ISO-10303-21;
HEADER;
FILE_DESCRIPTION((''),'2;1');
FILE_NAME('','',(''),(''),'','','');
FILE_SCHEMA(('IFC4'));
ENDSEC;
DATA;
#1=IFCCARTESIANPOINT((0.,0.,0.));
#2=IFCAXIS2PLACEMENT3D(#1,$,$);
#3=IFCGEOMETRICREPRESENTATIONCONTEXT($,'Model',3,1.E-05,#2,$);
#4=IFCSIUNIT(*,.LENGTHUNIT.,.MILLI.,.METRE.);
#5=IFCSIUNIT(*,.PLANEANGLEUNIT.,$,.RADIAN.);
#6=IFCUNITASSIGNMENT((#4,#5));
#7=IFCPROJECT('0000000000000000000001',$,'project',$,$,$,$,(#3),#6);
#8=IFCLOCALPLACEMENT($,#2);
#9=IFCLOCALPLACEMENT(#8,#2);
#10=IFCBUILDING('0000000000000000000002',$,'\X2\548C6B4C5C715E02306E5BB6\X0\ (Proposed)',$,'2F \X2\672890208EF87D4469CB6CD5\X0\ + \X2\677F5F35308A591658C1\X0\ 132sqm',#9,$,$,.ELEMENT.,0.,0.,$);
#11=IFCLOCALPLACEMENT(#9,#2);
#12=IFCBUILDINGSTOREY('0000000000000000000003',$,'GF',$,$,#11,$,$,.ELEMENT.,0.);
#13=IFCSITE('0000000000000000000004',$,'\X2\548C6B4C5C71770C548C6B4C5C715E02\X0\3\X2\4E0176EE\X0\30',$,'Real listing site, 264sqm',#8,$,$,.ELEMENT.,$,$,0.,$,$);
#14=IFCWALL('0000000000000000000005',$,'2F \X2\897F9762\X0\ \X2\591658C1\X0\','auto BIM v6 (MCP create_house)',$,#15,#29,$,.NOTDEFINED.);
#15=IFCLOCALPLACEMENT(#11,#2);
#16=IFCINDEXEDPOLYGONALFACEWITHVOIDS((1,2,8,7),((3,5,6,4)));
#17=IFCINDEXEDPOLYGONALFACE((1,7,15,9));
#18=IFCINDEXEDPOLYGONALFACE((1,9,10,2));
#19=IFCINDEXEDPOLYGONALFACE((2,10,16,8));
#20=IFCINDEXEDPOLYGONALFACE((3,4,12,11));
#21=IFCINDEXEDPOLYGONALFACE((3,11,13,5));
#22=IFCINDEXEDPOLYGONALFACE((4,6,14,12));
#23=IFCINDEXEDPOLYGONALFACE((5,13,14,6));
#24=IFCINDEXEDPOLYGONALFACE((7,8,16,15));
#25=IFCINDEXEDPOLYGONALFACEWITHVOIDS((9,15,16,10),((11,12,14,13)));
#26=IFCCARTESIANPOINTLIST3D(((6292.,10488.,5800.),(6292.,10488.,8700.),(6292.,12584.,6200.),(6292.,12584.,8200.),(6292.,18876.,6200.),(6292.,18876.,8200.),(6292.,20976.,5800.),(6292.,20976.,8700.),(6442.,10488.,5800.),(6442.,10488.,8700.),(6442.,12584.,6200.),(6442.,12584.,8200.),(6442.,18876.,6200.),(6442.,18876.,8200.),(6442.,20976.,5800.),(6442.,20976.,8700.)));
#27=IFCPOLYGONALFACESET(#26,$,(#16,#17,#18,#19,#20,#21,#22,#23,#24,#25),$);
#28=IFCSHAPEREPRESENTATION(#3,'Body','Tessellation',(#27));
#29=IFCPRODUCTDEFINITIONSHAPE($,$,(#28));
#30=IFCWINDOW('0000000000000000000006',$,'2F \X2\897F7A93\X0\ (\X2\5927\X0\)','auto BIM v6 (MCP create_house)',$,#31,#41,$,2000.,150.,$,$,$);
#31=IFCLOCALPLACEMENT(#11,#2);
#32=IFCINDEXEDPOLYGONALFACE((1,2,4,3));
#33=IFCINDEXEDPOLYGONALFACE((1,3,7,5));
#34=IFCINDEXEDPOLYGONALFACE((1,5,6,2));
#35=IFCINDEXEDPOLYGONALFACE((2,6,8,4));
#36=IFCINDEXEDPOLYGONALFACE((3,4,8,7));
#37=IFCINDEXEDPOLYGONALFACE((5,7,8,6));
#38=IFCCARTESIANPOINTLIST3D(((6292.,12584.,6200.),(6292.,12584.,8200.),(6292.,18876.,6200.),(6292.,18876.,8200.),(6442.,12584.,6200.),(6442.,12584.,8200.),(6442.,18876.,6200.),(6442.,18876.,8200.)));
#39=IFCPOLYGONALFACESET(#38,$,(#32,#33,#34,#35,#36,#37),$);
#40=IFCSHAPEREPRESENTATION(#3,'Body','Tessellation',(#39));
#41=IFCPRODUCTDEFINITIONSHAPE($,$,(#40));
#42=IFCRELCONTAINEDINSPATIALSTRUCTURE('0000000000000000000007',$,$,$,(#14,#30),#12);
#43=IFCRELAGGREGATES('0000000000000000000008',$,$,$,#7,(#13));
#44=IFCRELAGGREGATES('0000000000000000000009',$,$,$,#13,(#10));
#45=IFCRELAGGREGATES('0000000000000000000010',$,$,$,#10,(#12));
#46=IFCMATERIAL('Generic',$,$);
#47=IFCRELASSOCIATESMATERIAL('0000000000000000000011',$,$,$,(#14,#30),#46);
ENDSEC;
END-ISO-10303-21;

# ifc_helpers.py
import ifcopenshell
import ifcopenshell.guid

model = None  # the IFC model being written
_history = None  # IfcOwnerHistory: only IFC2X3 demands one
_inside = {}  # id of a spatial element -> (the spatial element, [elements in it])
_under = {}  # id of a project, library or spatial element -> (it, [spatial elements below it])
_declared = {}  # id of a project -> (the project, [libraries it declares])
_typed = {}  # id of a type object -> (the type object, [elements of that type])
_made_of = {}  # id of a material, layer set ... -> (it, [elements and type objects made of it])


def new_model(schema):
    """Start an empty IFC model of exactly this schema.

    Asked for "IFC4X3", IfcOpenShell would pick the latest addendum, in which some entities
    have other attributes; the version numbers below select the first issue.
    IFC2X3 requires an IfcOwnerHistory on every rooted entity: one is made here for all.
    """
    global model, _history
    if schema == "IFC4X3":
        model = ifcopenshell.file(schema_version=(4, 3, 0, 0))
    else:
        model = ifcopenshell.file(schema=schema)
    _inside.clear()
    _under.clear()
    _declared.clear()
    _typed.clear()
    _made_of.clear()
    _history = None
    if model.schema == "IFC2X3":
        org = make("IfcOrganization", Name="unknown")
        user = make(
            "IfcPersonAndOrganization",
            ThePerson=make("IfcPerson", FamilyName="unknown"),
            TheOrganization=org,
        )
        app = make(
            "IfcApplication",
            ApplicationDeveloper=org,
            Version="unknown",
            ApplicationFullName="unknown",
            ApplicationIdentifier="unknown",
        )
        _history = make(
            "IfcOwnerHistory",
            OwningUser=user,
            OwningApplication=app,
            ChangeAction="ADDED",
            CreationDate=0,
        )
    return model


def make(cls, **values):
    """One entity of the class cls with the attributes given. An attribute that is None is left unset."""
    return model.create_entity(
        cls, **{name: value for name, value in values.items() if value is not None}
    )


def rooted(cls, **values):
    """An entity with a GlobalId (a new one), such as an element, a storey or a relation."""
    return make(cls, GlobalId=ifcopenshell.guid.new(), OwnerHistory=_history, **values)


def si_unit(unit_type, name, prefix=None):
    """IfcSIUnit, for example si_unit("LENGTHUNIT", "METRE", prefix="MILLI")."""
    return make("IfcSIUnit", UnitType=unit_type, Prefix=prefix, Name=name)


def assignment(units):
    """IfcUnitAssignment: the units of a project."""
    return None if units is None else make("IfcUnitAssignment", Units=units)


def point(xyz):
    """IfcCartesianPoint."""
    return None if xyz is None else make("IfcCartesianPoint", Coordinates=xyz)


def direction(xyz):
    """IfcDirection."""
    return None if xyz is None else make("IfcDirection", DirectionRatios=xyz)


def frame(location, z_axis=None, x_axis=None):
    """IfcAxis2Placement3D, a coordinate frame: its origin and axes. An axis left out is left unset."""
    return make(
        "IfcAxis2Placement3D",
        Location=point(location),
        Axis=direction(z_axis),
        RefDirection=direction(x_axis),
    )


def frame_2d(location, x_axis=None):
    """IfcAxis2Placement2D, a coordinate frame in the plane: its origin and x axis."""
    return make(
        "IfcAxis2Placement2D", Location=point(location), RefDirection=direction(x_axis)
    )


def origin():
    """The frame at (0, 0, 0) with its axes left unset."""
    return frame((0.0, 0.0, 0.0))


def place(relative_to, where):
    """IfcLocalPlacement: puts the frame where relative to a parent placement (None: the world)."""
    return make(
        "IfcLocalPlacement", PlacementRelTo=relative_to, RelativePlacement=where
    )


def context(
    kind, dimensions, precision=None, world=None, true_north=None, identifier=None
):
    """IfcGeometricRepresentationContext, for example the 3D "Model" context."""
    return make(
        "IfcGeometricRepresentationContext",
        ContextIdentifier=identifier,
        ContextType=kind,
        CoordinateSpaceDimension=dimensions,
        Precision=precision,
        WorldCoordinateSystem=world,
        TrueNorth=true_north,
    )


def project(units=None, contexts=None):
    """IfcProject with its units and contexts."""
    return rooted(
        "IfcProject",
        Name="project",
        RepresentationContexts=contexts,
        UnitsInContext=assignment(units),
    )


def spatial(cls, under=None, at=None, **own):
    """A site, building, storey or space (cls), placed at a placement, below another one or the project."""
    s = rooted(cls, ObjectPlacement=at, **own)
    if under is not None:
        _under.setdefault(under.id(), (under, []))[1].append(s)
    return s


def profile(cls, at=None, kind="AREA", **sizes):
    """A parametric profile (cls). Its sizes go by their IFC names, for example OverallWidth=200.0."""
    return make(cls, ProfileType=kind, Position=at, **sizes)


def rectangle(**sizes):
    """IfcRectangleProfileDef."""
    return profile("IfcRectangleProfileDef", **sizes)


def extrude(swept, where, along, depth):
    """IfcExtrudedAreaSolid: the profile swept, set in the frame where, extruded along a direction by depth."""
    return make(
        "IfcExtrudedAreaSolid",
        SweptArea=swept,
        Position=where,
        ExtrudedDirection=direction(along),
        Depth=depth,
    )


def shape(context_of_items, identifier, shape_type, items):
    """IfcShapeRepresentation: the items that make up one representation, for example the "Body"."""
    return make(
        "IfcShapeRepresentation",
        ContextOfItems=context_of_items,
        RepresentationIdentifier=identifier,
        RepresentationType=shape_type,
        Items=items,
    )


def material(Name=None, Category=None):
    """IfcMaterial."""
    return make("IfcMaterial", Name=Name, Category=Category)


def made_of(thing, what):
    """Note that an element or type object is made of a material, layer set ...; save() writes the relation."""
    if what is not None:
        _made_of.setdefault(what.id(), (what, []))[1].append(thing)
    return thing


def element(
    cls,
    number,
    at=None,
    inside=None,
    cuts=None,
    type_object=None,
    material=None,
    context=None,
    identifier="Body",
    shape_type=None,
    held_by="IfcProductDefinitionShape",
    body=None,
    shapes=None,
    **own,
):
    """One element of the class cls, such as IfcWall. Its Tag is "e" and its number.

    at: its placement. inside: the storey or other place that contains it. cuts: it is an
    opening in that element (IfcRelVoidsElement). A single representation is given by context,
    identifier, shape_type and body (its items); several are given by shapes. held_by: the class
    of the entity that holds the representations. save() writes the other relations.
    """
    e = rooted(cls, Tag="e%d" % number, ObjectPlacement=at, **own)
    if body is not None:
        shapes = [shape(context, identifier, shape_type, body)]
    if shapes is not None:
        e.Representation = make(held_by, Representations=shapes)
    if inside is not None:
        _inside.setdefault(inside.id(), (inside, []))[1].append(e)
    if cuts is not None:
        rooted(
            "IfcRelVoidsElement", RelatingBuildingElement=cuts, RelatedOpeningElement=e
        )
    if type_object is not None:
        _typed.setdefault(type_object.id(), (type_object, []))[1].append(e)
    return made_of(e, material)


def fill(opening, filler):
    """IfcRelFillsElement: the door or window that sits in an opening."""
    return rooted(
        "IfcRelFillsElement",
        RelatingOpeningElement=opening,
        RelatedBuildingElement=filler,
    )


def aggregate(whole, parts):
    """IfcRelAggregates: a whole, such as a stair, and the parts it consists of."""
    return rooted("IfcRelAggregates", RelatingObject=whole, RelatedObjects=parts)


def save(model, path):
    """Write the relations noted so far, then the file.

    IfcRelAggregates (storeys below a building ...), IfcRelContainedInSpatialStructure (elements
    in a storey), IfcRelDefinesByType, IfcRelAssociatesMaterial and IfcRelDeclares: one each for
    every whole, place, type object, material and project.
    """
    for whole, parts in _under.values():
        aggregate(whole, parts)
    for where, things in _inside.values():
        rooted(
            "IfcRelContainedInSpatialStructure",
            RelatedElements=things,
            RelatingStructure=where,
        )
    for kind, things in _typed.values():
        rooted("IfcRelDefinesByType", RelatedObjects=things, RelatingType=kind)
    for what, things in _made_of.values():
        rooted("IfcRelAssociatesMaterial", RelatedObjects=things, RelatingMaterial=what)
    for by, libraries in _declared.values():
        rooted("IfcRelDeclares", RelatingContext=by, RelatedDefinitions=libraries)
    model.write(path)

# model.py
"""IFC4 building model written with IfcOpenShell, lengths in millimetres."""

from ifc_helpers import new_model, si_unit, frame, frame_2d, origin, place, context, project, spatial, rectangle, extrude, material, element, fill, save


model = new_model("IFC4")

# Units and contexts
model_context = context("Model", 3, precision=1e-05, world=origin())
ifc_project = project(units=[si_unit("LENGTHUNIT", "METRE", prefix="MILLI"), si_unit("PLANEANGLEUNIT", "RADIAN")], contexts=[model_context])

# Site, building, storey
site_placement = place(None, origin())
site = spatial("IfcSite", under=ifc_project, at=site_placement, Name="和歌山県和歌山市3丁目30", ObjectType="Real listing site, 264sqm", CompositionType="ELEMENT", RefElevation=0.0)
building_placement = place(site_placement, origin())
building = spatial("IfcBuilding", under=site, at=building_placement, Name="和歌山市の家 (Proposed)", ObjectType="2F 木造軸組構法 + 板張り外壁 132sqm", CompositionType="ELEMENT", ElevationOfRefHeight=0.0, ElevationOfTerrain=0.0)
storey_placement = place(building_placement, origin())
storey = spatial("IfcBuildingStorey", under=building, at=storey_placement, Name="GF", CompositionType="ELEMENT", Elevation=0.0)

# Shared definitions
ifc_material = material(Name="Generic")

# Wall, opening, window
wall_1_placement = place(storey_placement, frame((3146.0, 5244.0, 2900.0)))
wall_1 = element("IfcWall", 1, at=wall_1_placement, inside=storey, material=ifc_material, Name="2F 西面 外壁", Description="auto BIM v6 (MCP create_house)", PredefinedType="NOTDEFINED", context=model_context, shape_type="SweptSolid", body=[
    extrude(rectangle(XDim=150.0, YDim=10488.0, at=frame_2d((75.0, 5244.0))), frame((3146.0, 5244.0, 2900.0)), (0.0, 0.0, 1.0), 2900.0),
])
opening_1_placement = place(storey_placement, frame((3146.0, 6292.0, 3100.0)))
opening_1 = element("IfcOpeningElement", 2, at=opening_1_placement, cuts=wall_1, PredefinedType="NOTDEFINED", context=model_context, shape_type="SweptSolid", body=[
    extrude(rectangle(XDim=150.0, YDim=6292.0, at=frame_2d((75.0, 3146.0))), frame((3146.0, 6292.0, 3100.0)), (0.0, 0.0, 1.0), 2000.0),
])
window_1_placement = place(storey_placement, frame((3146.0, 6292.0, 3100.0)))
window_1 = element("IfcWindow", 3, at=window_1_placement, inside=storey, material=ifc_material, Name="2F 西窓 (大)", Description="auto BIM v6 (MCP create_house)", OverallHeight=2000.0, OverallWidth=150.0, context=model_context, shape_type="SweptSolid", body=[
    extrude(rectangle(XDim=150.0, YDim=6292.0, at=frame_2d((75.0, 3146.0))), frame((3146.0, 6292.0, 3100.0)), (0.0, 0.0, 1.0), 2000.0),
])
fill(opening_1, window_1)

save(model, "model.ifc")
